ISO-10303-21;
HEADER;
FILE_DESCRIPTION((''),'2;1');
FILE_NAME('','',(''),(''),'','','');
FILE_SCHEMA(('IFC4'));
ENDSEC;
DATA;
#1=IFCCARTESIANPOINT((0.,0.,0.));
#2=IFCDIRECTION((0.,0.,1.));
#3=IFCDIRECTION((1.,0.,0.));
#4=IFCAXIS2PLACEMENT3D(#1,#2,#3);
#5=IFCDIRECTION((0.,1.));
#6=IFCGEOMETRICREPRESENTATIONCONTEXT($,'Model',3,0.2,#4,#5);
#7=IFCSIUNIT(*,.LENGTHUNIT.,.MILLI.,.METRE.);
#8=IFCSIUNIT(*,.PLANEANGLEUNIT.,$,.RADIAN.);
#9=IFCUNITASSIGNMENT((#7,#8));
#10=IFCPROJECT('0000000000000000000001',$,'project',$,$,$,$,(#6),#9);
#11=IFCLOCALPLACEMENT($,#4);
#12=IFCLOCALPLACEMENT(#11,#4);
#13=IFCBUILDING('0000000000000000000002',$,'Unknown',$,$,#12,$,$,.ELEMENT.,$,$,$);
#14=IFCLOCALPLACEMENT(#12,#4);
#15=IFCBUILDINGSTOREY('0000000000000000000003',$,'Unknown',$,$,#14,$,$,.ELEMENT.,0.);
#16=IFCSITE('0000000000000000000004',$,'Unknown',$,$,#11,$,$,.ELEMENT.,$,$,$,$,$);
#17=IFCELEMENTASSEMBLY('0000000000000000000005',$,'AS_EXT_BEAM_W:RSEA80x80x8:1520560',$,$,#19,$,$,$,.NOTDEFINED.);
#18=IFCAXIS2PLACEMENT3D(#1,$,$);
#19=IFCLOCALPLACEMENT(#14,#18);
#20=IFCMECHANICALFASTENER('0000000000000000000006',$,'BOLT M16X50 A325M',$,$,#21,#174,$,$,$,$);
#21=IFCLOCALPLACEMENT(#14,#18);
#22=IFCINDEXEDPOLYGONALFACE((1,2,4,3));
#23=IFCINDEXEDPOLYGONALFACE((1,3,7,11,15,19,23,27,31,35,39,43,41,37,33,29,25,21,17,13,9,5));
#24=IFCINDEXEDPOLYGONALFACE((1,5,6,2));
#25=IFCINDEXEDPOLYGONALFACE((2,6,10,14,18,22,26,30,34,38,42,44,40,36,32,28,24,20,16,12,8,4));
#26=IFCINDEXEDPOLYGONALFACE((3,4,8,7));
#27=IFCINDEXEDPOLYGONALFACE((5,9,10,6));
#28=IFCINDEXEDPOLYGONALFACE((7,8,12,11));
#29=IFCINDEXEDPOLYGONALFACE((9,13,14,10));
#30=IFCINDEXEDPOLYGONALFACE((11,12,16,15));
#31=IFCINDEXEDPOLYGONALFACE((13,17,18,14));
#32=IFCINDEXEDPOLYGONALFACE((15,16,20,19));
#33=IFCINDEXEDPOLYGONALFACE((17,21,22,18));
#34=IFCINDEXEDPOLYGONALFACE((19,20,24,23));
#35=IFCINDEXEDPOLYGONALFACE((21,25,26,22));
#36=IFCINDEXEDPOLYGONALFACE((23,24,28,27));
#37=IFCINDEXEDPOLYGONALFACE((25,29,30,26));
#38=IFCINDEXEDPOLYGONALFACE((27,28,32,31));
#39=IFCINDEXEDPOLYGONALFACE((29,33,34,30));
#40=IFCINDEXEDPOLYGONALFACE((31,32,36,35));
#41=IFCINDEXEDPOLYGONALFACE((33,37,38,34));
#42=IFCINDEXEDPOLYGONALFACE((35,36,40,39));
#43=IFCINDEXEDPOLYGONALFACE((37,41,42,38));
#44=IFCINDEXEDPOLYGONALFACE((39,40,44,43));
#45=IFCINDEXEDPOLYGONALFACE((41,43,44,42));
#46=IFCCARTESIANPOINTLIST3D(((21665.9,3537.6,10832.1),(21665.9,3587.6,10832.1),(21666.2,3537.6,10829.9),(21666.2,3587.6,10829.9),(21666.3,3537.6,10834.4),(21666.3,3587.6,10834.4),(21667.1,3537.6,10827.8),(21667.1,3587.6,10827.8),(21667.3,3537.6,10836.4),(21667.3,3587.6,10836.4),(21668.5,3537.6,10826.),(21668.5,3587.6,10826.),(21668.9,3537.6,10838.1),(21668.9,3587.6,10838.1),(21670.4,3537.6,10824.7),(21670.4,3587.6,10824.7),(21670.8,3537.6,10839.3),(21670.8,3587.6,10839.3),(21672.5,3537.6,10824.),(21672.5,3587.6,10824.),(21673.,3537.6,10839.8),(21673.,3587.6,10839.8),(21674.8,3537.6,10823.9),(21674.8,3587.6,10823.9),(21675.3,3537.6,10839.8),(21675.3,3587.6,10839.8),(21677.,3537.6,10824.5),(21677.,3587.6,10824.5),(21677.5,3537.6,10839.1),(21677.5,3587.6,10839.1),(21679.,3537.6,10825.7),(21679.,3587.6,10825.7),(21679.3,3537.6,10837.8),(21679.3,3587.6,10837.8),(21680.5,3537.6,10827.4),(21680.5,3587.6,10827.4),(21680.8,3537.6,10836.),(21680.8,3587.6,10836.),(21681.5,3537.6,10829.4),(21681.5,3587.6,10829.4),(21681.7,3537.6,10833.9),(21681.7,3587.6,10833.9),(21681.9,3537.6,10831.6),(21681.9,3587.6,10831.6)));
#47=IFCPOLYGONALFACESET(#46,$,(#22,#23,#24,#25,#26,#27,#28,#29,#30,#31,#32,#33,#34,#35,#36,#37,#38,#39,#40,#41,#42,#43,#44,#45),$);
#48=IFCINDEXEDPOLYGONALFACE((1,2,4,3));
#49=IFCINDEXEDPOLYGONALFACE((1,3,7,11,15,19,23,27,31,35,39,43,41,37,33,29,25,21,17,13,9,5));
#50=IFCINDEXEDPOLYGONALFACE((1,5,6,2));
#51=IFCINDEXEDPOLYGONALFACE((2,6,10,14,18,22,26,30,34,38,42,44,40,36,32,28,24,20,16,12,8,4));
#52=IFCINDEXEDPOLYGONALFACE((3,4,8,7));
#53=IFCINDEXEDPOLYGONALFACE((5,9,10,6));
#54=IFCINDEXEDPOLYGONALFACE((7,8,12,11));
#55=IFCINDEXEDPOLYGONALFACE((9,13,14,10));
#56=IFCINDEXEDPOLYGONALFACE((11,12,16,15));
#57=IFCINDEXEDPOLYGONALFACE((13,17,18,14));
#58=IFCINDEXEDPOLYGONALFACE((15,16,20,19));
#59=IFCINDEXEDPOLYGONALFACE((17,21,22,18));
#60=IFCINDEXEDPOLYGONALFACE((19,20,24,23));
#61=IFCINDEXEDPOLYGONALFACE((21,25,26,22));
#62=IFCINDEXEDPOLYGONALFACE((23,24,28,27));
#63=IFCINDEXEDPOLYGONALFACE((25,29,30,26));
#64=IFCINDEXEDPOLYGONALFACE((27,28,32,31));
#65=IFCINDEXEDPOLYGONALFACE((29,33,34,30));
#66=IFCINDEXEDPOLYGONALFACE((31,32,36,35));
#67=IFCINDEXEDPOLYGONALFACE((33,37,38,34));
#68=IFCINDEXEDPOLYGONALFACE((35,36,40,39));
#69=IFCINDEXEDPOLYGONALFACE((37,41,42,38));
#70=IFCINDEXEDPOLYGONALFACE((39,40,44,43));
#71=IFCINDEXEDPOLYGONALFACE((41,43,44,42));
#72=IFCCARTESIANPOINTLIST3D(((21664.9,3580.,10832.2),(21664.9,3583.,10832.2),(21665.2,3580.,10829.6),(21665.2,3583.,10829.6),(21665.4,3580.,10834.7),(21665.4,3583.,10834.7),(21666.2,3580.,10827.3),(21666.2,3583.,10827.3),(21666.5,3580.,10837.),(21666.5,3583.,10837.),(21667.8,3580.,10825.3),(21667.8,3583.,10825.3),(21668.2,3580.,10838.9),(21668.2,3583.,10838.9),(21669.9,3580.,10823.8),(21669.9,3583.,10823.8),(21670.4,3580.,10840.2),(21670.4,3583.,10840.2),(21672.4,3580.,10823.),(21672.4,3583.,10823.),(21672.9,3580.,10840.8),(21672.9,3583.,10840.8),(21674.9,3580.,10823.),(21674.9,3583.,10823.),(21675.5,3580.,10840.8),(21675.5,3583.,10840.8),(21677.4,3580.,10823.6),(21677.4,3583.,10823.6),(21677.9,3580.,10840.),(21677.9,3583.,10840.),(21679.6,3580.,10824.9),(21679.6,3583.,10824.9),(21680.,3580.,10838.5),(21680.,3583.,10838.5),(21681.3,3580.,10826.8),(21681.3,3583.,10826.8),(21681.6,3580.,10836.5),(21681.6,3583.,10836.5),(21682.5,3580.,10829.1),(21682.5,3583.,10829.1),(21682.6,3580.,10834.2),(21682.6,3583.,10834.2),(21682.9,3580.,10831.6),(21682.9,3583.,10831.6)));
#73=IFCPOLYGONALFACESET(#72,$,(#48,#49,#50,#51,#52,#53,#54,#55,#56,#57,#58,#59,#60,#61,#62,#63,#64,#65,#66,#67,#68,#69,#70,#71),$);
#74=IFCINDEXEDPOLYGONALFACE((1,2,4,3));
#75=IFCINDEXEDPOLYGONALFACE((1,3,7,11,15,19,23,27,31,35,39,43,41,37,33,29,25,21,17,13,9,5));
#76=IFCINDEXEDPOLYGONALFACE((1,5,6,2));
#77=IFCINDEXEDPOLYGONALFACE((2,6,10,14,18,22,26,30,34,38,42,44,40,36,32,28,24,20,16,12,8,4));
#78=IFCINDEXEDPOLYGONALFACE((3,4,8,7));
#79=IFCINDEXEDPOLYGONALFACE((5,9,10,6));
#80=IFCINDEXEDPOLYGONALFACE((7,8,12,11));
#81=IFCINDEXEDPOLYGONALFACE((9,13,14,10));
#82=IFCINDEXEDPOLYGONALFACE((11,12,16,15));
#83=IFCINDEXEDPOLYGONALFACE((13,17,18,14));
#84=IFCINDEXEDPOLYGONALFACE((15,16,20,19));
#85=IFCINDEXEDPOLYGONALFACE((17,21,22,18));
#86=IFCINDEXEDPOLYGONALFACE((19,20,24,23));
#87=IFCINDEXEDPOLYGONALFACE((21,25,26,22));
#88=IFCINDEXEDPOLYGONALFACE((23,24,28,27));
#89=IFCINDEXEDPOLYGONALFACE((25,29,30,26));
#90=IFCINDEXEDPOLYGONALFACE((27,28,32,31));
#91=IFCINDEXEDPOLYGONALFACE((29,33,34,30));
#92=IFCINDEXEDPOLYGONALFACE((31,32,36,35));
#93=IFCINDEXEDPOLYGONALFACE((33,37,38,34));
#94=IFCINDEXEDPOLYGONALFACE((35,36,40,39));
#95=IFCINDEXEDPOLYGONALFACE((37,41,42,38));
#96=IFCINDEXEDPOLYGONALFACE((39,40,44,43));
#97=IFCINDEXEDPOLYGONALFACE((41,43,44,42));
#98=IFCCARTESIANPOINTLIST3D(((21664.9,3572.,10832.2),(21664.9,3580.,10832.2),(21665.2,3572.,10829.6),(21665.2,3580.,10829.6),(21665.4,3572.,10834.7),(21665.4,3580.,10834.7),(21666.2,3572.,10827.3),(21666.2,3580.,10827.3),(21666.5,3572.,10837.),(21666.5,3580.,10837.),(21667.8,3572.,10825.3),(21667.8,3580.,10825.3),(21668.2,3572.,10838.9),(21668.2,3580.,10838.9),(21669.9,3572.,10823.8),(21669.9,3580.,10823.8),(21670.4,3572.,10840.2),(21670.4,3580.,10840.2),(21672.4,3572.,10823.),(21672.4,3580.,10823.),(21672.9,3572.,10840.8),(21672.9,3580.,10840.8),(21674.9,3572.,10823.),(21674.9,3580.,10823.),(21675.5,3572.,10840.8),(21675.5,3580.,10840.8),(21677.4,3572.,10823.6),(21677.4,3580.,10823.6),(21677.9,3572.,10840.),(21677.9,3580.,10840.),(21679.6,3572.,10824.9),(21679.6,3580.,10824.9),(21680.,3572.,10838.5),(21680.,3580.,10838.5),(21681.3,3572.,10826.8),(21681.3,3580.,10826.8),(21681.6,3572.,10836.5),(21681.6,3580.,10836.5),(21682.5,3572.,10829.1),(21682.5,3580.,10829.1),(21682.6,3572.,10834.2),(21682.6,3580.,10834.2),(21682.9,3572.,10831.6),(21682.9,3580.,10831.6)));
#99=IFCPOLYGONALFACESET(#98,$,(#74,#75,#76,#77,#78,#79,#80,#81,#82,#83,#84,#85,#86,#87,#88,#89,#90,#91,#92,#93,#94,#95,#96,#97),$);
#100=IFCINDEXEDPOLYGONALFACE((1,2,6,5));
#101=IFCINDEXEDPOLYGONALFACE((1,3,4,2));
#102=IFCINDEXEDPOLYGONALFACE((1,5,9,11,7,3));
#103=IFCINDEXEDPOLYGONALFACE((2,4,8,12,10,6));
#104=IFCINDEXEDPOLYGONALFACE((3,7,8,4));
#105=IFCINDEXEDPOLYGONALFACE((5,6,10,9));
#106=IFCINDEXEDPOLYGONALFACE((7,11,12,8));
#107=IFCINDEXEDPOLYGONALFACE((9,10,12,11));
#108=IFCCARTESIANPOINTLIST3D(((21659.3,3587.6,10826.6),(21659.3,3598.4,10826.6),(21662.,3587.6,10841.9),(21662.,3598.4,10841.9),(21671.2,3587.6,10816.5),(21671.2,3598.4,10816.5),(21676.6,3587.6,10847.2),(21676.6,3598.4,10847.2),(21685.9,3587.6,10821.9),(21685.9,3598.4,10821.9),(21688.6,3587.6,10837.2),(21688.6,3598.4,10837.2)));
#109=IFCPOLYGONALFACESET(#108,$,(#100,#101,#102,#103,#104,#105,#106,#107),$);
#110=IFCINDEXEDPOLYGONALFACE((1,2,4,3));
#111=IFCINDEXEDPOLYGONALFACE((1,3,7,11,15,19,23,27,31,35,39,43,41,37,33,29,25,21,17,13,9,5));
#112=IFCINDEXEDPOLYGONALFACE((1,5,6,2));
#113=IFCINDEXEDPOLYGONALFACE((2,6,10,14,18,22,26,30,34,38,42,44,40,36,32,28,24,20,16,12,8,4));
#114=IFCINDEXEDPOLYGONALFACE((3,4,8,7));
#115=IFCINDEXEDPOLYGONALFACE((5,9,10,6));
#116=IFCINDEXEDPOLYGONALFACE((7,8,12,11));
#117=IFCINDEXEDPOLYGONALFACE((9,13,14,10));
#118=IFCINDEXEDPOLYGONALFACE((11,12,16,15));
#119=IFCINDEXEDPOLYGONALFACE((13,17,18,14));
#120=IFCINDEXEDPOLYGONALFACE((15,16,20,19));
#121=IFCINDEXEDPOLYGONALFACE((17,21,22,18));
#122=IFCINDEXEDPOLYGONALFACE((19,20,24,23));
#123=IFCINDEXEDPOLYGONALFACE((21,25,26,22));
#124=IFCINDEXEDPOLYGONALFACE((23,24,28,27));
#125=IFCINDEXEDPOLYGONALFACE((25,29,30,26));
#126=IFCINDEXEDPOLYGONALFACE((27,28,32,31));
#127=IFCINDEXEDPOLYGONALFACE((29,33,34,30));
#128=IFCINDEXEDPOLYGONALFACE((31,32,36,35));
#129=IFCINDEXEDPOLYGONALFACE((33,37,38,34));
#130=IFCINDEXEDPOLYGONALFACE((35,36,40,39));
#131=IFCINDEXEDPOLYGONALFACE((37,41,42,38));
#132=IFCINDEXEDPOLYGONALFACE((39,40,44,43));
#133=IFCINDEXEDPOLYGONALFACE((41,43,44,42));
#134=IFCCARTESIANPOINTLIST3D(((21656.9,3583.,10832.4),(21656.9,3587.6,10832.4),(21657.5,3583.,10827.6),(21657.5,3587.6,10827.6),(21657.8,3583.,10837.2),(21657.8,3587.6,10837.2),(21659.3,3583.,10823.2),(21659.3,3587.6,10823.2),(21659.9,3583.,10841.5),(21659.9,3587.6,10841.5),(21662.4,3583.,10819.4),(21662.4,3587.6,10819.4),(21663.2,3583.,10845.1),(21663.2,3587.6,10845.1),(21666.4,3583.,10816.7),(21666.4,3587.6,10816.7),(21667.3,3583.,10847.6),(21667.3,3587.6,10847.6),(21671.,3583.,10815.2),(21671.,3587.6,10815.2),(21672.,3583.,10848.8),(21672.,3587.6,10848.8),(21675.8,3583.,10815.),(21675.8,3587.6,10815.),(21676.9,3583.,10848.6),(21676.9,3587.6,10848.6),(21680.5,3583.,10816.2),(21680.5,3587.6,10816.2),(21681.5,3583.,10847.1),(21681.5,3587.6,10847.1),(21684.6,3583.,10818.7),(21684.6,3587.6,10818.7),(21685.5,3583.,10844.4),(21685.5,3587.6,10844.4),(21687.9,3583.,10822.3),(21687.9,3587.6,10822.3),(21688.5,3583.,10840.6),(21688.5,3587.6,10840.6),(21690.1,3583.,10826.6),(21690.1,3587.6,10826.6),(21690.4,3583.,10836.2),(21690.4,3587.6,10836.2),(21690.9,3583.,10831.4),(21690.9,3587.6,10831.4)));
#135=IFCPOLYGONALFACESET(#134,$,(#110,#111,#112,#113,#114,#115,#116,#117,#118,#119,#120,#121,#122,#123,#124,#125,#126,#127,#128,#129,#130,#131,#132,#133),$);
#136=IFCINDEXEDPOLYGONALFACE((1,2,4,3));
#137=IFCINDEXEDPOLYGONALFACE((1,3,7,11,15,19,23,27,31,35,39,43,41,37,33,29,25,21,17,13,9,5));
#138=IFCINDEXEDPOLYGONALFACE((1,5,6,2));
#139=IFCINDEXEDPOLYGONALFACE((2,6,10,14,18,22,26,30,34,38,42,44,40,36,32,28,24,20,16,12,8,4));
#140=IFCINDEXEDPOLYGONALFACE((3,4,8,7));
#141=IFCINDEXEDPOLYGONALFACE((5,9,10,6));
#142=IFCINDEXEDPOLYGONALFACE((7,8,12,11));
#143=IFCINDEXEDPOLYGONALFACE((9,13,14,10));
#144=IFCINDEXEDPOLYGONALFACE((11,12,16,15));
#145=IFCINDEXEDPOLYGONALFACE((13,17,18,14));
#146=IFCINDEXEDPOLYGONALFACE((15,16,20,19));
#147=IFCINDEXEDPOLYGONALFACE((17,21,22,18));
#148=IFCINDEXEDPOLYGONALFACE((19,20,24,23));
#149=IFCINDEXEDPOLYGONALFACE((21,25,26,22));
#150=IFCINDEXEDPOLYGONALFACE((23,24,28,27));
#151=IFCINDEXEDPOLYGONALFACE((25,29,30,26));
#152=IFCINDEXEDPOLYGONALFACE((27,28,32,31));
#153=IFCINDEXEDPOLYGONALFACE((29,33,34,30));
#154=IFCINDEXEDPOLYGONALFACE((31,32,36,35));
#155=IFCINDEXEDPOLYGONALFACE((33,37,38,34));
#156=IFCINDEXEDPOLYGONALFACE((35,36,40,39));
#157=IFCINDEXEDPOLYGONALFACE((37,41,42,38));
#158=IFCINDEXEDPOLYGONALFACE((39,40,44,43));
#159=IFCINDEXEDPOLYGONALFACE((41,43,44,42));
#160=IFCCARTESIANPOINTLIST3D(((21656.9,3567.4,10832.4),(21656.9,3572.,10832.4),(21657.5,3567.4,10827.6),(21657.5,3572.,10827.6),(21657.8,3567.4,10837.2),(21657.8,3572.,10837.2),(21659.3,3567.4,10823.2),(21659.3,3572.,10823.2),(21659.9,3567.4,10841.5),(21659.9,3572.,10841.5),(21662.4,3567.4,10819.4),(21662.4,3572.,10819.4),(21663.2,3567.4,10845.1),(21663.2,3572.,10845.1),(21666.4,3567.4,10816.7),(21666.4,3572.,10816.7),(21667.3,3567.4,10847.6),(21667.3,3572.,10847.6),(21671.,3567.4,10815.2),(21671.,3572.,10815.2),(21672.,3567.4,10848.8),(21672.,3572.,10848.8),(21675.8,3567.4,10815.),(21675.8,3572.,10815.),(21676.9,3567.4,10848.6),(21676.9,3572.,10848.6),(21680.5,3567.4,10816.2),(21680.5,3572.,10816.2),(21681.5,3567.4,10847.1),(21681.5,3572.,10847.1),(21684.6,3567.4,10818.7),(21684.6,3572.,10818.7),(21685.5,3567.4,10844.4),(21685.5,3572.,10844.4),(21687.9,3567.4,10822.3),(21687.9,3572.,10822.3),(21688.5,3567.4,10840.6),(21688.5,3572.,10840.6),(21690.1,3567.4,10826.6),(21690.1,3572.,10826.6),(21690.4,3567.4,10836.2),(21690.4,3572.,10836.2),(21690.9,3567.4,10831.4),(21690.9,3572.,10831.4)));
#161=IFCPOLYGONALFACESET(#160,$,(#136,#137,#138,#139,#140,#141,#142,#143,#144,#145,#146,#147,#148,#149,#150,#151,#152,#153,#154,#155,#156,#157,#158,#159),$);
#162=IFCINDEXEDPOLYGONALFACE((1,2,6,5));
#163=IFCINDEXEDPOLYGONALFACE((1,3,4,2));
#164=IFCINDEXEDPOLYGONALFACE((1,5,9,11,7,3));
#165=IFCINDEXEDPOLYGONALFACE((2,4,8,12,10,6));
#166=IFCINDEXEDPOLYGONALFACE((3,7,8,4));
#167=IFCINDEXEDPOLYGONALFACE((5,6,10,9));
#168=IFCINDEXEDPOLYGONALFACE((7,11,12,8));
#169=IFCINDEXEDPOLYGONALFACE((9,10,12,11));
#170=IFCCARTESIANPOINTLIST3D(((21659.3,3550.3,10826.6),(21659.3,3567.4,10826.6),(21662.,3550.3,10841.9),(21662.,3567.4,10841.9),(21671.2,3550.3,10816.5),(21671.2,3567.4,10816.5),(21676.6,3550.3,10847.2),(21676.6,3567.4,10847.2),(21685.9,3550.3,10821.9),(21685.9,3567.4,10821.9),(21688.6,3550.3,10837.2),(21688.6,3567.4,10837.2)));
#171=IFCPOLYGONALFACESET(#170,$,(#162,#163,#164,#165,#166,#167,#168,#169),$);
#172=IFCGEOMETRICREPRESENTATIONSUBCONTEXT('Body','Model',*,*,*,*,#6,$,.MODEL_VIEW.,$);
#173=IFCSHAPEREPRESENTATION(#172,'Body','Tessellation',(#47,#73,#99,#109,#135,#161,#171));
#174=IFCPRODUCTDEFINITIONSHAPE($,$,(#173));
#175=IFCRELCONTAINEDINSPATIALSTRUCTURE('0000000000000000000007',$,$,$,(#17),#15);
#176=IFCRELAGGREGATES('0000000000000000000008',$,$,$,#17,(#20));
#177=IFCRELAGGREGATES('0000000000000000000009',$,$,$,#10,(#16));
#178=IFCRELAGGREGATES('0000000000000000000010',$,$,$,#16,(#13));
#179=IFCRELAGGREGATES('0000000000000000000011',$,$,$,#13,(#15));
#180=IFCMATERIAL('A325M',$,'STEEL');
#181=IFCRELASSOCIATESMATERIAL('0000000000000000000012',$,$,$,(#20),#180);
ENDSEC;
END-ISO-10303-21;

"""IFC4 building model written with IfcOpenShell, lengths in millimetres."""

from ifc_helpers import new_model, si_unit, direction, frame, origin_with_axes, place, context, subcontext, project, spatial, line, arc, indexed_curve, outline, extrude, source, transform, mapped, material, element, aggregate, save


model = new_model("IFC4")

# Units and contexts
model_context = context("Model", 3, precision=0.2, world=origin_with_axes(), true_north=direction((0.0, 1.0)))
body_context = subcontext(model_context, "Body", "Model", "MODEL_VIEW")
ifc_project = project(units=[si_unit("LENGTHUNIT", "METRE", prefix="MILLI"), si_unit("PLANEANGLEUNIT", "RADIAN")], contexts=[model_context])

# Site, building, storey
site_placement = place(None, origin_with_axes())
site = spatial("IfcSite", under=ifc_project, at=site_placement, Name="Unknown", CompositionType="ELEMENT")
building_placement = place(site_placement, origin_with_axes())
building = spatial("IfcBuilding", under=site, at=building_placement, Name="Unknown", CompositionType="ELEMENT")
storey_placement = place(building_placement, origin_with_axes())
storey = spatial("IfcBuildingStorey", under=building, at=storey_placement, Name="Unknown", CompositionType="ELEMENT", Elevation=0.0)

# Shared definitions
ifc_material_1 = material(Name="A325M", Category="STEEL")
shared_shape = source(origin_with_axes(), body_context, "Body", "SweptSolid", [
    extrude(outline(indexed_curve([(8.0, 0.0), (0.0, 8.0), (-8.0, 0.0), (0.0, -8.0)], segments=[arc(1, 2, 3), arc(3, 4, 1)])), frame((0.0, 0.0, 15.6), z_axis=(0.0, 0.0, -1.0), x_axis=(0.0, 1.0, 0.0)), (0.0, 0.0, 1.0), 50.0),
    extrude(outline(indexed_curve([(9.0, 0.0), (0.0, 9.0), (-9.0, 0.0), (0.0, -9.0)], segments=[arc(1, 2, 3), arc(3, 4, 1)])), frame((0.0, 0.0, 11.0), z_axis=(0.0, 0.0, -1.0), x_axis=(0.0, 1.0, 0.0)), (0.0, 0.0, 1.0), 3.0),
    extrude(outline(indexed_curve([(9.0, 0.0), (0.0, 9.0), (-9.0, 0.0), (0.0, -9.0)], segments=[arc(1, 2, 3), arc(3, 4, 1)])), frame((0.0, 0.0, 8.0), z_axis=(0.0, 0.0, -1.0), x_axis=(0.0, 1.0, 0.0)), (0.0, 0.0, 1.0), 8.0),
    extrude(outline(indexed_curve([(15.6, 0.0), (7.8, 13.5), (-7.8, 13.5), (-15.6, 0.0), (-7.8, -13.5), (7.8, -13.5)], segments=[line(1, 2, 3, 4, 5, 6, 1)])), frame((0.0, 0.0, 26.4), z_axis=(0.0, 0.0, -1.0), x_axis=(0.0, 1.0, 0.0)), (0.0, 0.0, 1.0), 10.8),
    extrude(outline(indexed_curve([(17.0, 0.0), (0.0, 17.0), (-17.0, 0.0), (0.0, -17.0)], segments=[arc(1, 2, 3), arc(3, 4, 1)])), frame((0.0, 0.0, 15.6), z_axis=(0.0, 0.0, -1.0), x_axis=(0.0, 1.0, 0.0)), (0.0, 0.0, 1.0), 4.6),
    extrude(outline(indexed_curve([(17.0, 0.0), (0.0, 17.0), (-17.0, 0.0), (0.0, -17.0)], segments=[arc(1, 2, 3), arc(3, 4, 1)])), frame((0.0, 0.0, 0.0), z_axis=(0.0, 0.0, -1.0), x_axis=(0.0, 1.0, 0.0)), (0.0, 0.0, 1.0), 4.6),
    extrude(outline(indexed_curve([(15.6, 0.0), (7.8, 13.5), (-7.8, 13.5), (-15.6, 0.0), (-7.8, -13.5), (7.8, -13.5)], segments=[line(1, 2, 3, 4, 5, 6, 1)])), frame((0.0, 0.0, -4.6), z_axis=(0.0, 0.0, -1.0), x_axis=(0.0, 1.0, 0.0)), (0.0, 0.0, 1.0), 17.1),
])

# Element assembly, mechanical fastener
assembly_1_placement = place(storey_placement, frame((21611.5, 3540.0, 10837.8), z_axis=(0.0, -1.0, 0.0), x_axis=(0.984808, 0.0, -0.173648)))
assembly_1 = element("IfcElementAssembly", 1, at=assembly_1_placement, inside=storey, Name="AS_EXT_BEAM_W:RSEA80x80x8:1520560", PredefinedType="NOTDEFINED")
mechanical_fastener_1_placement = place(assembly_1_placement, frame((62.5, 5.0, -32.0), z_axis=(0.0, 0.0, -1.0), x_axis=(1.0, 0.0, 0.0)))
mechanical_fastener_1 = element("IfcMechanicalFastener", 2, at=mechanical_fastener_1_placement, material=ifc_material_1, Name="BOLT M16X50 A325M", context=body_context, shape_type="MappedRepresentation", body=[
    mapped(shared_shape, transform((0.0, 0.0, 0.0))),
])
aggregate(assembly_1, [mechanical_fastener_1])

save(model, "model.ifc")
